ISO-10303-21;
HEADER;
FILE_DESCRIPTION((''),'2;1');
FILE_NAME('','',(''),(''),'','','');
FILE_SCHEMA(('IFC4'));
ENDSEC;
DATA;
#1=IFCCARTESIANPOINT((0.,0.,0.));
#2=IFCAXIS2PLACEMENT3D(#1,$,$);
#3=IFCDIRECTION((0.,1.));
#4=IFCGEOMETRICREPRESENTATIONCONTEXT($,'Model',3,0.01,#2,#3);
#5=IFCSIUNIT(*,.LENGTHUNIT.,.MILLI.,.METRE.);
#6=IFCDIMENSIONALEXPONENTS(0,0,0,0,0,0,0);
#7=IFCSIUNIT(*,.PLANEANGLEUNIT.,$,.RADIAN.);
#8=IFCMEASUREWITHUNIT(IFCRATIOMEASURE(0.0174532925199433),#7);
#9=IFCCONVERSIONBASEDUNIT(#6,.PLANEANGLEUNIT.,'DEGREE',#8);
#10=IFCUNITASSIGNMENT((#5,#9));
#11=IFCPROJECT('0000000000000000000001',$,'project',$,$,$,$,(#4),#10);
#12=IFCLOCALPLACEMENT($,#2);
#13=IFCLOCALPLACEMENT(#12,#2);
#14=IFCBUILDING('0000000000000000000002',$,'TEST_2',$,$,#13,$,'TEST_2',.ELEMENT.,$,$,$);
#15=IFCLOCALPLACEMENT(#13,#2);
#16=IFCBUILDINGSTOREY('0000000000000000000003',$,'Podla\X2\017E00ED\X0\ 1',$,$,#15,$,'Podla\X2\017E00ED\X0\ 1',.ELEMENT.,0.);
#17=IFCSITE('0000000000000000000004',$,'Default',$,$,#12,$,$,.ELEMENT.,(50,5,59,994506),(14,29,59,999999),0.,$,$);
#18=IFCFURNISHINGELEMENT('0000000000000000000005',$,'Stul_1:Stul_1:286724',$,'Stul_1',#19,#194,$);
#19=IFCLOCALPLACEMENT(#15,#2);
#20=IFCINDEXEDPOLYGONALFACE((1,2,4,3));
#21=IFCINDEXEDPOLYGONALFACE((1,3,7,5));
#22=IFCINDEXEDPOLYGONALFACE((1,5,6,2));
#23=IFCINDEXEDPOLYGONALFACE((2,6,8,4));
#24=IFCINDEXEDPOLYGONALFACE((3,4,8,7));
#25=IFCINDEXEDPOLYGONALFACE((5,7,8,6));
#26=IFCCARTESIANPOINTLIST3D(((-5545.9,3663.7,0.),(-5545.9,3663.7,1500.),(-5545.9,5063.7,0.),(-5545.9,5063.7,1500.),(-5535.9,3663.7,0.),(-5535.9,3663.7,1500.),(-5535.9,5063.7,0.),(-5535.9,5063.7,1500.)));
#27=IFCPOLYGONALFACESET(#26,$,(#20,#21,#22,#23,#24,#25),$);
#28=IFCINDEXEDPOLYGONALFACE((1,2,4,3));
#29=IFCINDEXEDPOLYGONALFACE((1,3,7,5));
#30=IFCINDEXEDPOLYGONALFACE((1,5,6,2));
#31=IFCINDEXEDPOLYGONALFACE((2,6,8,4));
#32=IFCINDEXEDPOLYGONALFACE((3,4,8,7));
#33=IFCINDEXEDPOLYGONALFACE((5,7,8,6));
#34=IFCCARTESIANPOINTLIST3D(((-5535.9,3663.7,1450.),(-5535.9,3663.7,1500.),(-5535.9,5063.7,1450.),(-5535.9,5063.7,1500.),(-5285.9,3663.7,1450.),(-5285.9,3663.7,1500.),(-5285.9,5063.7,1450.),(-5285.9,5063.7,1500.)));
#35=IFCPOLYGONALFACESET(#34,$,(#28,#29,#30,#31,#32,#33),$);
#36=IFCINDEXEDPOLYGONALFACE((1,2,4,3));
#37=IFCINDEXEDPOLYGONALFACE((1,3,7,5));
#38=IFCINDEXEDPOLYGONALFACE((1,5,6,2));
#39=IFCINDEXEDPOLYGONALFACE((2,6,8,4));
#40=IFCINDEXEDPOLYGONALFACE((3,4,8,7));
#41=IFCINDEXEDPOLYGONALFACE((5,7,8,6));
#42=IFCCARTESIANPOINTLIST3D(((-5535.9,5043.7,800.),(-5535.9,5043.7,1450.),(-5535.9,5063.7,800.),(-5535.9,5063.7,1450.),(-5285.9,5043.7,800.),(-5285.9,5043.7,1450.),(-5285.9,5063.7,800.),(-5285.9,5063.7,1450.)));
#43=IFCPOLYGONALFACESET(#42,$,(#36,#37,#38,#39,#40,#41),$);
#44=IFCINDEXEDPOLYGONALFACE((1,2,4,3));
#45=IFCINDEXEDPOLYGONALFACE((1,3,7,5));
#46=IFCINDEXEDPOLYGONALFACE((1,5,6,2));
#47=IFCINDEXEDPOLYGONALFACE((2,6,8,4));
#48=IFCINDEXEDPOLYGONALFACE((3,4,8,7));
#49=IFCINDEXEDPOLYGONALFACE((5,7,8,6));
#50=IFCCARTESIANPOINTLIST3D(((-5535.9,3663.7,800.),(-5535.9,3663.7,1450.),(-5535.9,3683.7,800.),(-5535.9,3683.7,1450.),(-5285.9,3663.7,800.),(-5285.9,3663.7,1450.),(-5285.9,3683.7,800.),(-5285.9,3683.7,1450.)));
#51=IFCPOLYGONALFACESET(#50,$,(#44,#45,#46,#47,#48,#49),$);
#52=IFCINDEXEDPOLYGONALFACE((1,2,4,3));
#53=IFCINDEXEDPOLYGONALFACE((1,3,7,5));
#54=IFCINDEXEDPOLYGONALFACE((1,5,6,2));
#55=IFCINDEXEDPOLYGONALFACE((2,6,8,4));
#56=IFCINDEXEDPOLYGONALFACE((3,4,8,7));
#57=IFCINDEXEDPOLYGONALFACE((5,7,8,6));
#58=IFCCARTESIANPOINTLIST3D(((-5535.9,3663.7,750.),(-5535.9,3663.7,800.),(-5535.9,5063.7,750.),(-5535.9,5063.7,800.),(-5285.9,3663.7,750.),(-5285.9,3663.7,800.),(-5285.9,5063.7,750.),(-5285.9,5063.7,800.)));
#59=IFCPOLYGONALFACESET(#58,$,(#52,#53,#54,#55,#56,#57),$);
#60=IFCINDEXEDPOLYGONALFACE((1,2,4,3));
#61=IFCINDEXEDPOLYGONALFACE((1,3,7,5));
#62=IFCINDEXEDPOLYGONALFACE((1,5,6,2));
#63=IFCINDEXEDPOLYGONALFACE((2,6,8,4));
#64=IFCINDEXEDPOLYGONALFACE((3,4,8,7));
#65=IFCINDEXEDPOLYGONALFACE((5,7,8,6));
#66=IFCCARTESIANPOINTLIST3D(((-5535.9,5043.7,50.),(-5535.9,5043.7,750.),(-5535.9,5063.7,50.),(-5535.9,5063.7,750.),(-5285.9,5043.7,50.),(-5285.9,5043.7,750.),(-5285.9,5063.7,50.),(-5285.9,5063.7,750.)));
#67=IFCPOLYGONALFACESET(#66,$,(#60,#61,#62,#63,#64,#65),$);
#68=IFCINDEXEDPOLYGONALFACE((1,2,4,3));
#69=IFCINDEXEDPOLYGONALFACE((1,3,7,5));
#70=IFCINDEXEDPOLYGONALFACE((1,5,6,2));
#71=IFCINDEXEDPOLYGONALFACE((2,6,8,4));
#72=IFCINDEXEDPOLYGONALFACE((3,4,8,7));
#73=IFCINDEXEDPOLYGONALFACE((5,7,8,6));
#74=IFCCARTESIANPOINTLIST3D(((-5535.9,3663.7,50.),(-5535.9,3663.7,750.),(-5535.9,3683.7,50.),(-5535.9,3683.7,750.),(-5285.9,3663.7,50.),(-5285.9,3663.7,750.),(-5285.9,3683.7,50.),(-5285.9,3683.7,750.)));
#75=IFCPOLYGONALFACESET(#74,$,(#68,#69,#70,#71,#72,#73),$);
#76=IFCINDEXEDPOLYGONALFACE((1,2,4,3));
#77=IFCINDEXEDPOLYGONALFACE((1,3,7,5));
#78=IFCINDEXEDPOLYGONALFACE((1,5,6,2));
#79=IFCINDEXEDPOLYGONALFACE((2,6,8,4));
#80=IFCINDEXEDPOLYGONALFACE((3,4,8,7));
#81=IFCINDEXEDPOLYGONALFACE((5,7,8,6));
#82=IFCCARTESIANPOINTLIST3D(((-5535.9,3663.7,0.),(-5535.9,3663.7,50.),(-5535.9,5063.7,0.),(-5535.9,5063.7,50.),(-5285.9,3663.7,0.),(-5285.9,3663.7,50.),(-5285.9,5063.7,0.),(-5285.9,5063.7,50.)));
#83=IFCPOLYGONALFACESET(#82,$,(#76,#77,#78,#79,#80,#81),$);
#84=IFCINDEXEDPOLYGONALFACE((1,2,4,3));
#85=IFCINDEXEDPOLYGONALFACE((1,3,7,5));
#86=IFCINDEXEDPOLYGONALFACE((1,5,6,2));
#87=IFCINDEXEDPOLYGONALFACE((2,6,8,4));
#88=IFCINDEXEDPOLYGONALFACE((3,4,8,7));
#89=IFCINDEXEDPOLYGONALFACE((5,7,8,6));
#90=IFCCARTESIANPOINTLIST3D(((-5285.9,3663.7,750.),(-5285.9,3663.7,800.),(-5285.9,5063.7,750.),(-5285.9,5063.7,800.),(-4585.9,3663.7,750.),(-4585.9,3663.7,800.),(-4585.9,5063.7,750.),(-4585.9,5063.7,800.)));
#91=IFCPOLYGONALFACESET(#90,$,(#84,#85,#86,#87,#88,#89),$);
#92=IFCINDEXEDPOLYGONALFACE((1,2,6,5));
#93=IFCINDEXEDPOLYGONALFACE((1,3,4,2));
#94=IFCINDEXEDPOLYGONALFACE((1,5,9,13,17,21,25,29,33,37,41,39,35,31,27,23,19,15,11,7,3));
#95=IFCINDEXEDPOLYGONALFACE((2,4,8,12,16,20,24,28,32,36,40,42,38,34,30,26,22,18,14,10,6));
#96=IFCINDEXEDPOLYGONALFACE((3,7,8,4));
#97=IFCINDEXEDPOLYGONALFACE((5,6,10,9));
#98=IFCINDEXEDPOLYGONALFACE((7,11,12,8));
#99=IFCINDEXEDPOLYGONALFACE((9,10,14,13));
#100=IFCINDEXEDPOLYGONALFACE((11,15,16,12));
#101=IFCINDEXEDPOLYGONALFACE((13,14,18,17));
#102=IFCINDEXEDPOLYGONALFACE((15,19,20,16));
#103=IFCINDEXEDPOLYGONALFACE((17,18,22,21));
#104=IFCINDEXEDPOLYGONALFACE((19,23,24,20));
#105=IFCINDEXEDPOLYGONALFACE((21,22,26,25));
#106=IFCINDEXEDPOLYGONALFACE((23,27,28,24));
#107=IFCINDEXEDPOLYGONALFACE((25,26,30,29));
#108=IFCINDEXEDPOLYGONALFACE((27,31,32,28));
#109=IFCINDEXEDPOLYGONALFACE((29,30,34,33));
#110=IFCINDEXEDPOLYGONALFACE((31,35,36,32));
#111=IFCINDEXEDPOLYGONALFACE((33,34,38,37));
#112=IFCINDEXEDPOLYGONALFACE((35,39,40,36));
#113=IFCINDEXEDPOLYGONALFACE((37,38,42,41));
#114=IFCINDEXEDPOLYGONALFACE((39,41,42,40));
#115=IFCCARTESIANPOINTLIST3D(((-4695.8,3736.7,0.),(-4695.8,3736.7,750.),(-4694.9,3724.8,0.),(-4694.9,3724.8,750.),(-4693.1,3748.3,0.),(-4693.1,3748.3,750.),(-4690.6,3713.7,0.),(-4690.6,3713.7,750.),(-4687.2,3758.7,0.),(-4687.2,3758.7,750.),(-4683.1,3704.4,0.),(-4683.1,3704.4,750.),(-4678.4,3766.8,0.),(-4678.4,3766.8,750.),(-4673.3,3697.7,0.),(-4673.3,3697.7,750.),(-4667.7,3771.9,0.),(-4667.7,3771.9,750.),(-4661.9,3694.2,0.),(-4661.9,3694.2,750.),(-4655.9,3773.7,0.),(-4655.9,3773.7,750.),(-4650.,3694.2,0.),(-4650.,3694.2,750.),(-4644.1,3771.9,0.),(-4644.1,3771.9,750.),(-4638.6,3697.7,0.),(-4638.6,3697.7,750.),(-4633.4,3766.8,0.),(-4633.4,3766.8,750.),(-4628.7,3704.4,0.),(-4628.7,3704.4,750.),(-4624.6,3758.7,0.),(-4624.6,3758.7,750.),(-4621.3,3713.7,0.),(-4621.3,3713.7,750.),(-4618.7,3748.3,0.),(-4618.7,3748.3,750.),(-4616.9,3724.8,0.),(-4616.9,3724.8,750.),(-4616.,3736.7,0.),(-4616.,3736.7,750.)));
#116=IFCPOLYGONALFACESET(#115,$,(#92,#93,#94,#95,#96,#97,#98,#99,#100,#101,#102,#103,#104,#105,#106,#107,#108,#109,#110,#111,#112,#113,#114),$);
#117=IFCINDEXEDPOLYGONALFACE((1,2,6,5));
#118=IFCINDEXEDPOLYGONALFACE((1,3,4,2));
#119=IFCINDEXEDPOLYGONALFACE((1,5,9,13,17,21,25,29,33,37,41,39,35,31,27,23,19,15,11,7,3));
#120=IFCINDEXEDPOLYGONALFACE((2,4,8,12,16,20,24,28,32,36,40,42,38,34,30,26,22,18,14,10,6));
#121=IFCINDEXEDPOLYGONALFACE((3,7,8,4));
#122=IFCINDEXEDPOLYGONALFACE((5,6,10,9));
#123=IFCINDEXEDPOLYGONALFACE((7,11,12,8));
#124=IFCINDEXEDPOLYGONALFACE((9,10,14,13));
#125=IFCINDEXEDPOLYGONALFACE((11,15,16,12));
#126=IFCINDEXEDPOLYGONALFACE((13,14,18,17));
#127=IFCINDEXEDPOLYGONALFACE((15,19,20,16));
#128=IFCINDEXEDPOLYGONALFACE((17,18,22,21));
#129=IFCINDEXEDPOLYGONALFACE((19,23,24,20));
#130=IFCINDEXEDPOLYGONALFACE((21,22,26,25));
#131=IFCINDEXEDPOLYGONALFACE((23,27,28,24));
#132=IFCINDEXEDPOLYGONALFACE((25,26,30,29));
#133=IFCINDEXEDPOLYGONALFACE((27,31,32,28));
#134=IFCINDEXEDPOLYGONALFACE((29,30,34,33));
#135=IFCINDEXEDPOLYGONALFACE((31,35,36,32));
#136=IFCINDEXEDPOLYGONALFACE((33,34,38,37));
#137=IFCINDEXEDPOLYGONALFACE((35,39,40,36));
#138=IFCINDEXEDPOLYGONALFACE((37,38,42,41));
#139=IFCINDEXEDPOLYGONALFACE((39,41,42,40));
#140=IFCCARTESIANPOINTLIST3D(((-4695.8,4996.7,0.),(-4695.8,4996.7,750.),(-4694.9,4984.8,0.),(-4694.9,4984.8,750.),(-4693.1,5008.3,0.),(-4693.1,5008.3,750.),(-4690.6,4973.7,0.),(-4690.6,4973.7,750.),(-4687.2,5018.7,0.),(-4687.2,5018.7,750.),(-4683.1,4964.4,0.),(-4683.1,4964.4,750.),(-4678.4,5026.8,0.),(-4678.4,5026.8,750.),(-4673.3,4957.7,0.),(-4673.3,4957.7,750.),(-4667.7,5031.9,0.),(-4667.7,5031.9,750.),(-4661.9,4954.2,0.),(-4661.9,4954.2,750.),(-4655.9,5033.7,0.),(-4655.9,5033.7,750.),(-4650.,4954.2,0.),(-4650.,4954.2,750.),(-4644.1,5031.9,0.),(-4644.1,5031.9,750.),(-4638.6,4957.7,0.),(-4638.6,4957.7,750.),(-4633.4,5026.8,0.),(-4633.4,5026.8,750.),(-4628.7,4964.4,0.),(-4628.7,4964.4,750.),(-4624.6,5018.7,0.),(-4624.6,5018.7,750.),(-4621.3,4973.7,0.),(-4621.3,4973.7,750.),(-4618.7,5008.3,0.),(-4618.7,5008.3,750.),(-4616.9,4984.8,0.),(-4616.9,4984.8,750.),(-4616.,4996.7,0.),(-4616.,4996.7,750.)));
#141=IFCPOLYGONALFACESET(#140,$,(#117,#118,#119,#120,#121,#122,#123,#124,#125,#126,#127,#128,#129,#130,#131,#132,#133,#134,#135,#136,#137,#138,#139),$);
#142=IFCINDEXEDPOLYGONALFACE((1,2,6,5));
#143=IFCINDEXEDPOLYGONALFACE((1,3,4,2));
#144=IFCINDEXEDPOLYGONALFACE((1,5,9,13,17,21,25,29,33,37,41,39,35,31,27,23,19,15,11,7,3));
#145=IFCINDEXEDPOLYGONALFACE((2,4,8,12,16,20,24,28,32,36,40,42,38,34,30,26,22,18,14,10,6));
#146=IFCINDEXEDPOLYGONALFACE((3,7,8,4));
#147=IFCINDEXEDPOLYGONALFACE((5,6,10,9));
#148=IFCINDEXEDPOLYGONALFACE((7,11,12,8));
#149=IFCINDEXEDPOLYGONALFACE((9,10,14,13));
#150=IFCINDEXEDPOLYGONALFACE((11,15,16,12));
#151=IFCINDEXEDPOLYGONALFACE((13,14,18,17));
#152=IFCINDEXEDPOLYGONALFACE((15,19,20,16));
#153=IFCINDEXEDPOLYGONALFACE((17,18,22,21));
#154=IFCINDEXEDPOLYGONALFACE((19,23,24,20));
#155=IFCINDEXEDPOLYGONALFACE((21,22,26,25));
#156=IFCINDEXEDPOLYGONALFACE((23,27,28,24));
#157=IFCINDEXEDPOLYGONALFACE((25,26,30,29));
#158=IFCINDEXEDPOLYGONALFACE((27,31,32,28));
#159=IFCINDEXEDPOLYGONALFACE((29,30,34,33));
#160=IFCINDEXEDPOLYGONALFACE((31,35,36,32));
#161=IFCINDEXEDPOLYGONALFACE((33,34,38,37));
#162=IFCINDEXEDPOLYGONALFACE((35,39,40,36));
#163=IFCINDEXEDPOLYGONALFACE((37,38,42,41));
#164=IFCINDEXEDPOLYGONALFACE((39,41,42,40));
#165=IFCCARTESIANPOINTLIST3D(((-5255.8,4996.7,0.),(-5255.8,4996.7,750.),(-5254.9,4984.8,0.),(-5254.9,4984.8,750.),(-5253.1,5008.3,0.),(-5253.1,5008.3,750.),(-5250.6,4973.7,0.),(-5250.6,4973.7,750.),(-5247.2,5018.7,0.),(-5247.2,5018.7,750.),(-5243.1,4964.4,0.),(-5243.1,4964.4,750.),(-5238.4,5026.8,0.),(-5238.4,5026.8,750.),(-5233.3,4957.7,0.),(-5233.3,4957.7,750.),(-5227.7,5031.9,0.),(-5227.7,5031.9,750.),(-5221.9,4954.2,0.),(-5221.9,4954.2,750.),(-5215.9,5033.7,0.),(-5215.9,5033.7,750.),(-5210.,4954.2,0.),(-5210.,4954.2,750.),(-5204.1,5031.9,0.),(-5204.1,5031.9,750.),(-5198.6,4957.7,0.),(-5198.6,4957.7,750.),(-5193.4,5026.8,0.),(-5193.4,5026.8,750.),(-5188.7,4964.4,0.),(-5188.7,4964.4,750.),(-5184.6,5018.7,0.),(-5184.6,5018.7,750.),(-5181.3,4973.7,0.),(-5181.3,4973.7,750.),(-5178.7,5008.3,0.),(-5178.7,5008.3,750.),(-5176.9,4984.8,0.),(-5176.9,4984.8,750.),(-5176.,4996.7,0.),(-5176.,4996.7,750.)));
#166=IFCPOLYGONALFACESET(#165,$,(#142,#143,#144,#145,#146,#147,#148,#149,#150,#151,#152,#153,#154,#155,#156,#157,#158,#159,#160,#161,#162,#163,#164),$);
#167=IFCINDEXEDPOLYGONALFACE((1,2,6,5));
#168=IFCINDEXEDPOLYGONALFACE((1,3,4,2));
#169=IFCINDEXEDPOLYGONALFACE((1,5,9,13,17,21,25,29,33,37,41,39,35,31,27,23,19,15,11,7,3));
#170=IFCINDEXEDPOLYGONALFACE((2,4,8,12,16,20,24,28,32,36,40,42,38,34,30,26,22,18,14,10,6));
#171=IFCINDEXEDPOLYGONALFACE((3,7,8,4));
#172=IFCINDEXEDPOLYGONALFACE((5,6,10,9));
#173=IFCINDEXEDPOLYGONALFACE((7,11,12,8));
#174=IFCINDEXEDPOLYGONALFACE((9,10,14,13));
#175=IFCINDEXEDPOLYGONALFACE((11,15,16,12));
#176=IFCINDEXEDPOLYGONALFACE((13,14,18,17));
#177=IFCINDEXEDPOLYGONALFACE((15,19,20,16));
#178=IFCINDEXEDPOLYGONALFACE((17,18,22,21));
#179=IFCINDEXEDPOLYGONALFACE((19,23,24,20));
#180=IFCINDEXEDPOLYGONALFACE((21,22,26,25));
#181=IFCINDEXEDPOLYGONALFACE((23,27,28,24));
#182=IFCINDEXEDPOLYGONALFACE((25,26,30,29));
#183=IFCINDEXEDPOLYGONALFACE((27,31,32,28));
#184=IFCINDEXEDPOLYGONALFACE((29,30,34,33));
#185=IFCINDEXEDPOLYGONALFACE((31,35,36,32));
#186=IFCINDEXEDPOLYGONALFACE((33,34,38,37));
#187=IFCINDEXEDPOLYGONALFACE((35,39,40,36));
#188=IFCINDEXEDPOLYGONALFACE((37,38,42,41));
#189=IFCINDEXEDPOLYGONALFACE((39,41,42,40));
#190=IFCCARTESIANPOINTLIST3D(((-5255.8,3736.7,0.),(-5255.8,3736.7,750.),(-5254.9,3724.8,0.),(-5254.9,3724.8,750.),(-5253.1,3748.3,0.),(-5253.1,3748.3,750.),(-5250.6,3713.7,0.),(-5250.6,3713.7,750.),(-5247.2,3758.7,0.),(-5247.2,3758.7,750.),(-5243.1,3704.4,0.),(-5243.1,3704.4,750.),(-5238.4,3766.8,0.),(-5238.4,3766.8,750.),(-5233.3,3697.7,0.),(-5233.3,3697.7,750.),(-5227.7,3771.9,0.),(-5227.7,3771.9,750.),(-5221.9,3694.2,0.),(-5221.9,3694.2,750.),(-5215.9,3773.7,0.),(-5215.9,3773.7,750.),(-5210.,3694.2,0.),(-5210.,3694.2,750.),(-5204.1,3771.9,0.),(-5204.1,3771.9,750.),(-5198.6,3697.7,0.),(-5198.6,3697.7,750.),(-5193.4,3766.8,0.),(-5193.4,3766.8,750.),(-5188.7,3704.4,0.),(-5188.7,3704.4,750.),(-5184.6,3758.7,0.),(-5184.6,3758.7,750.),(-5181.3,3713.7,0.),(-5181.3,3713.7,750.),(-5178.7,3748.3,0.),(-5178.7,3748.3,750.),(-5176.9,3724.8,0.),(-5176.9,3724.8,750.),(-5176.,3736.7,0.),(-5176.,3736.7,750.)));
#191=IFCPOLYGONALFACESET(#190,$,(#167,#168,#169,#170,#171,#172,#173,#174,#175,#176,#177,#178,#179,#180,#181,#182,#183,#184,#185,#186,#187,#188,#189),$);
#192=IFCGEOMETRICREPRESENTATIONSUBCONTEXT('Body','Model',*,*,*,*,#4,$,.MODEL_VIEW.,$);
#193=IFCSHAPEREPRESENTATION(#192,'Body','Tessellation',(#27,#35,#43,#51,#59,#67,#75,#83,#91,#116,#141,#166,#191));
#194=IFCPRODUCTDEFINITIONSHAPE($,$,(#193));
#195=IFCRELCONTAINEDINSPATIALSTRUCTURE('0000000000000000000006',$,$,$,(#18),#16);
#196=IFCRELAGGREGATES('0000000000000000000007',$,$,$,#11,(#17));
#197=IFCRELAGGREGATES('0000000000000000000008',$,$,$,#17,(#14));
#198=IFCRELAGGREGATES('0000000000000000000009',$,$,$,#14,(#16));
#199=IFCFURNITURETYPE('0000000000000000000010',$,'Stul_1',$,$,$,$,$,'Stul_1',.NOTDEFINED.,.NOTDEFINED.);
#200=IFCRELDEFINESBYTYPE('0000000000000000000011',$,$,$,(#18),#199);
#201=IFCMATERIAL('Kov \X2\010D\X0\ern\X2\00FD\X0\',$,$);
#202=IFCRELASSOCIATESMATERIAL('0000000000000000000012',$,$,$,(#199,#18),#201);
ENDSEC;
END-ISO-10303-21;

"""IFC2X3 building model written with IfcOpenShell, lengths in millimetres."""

from ifc_helpers import new_model, entity, si_unit, converted_unit, direction, frame, frame_2d, origin, origin_2d_with_axis, place, context, subcontext, project, spatial, rectangle, circle, extrude, source, transform, mapped, material, type_object, type_shapes, element, save


model = new_model("IFC2X3")

# Units and contexts
model_context = context("Model", 3, precision=0.01, world=origin(), true_north=direction((0.0, 1.0)))
body_context = subcontext(model_context, "Body", "Model", "MODEL_VIEW")
ifc_project = project(units=[si_unit("LENGTHUNIT", "METRE", prefix="MILLI"), converted_unit("PLANEANGLEUNIT", "DEGREE", entity("IfcRatioMeasure", 0.0174532925199433), si_unit("PLANEANGLEUNIT", "RADIAN"), dimensions=[0, 0, 0, 0, 0, 0, 0])], contexts=[model_context])

# Site, building, storey
site_placement = place(None, origin())
site = spatial("IfcSite", under=ifc_project, at=site_placement, Name="Default", CompositionType="ELEMENT", RefLatitude=(50, 5, 59, 994506), RefLongitude=(14, 29, 59, 999999), RefElevation=0.0)
building_placement = place(site_placement, origin())
building = spatial("IfcBuilding", under=site, at=building_placement, Name="TEST_2", LongName="TEST_2", CompositionType="ELEMENT")
storey_placement = place(building_placement, origin())
storey = spatial("IfcBuildingStorey", under=building, at=storey_placement, Name="Podlaží 1", LongName="Podlaží 1", CompositionType="ELEMENT", Elevation=0.0)

# Furnishing element
ifc_material_1 = material(Name="Kov černý")
furniture_type = type_object("IfcFurnitureType", Name="Stul_1", ElementType="Stul_1", material=ifc_material_1)
shared_shape_1 = source(origin(), body_context, "Body", "SweptSolid", [
    extrude(rectangle(XDim=1400.0, YDim=10.0, at=origin_2d_with_axis()), frame((0.0, 605.0, 0.0), z_axis=(0.0, 0.0, 1.0), x_axis=(-1.0, 0.0, 0.0)), (0.0, 0.0, 1.0), 1500.0),
    extrude(rectangle(XDim=1400.0, YDim=250.0, at=frame_2d((0.0, 0.0), x_axis=(1.0, 0.0))), frame((0.0, 475.0, 1450.0), z_axis=(0.0, 0.0, 1.0), x_axis=(-1.0, 0.0, 0.0)), (0.0, 0.0, 1.0), 50.0),
    extrude(rectangle(XDim=20.0, YDim=250.0, at=origin_2d_with_axis()), frame((690.0, 475.0, 800.0), z_axis=(0.0, 0.0, 1.0), x_axis=(-1.0, 0.0, 0.0)), (0.0, 0.0, 1.0), 650.0),
    extrude(rectangle(XDim=20.0, YDim=250.0, at=frame_2d((0.0, 0.0), x_axis=(1.0, 0.0))), frame((-690.0, 475.0, 800.0), z_axis=(0.0, 0.0, 1.0), x_axis=(-1.0, 0.0, 0.0)), (0.0, 0.0, 1.0), 650.0),
    extrude(rectangle(XDim=1400.0, YDim=250.0, at=origin_2d_with_axis()), frame((0.0, 475.0, 750.0), z_axis=(0.0, 0.0, 1.0), x_axis=(-1.0, 0.0, 0.0)), (0.0, 0.0, 1.0), 50.0),
    extrude(rectangle(XDim=20.0, YDim=250.0, at=origin_2d_with_axis()), frame((690.0, 475.0, 50.0), z_axis=(0.0, 0.0, 1.0), x_axis=(-1.0, 0.0, 0.0)), (0.0, 0.0, 1.0), 700.0),
    extrude(rectangle(XDim=20.0, YDim=250.0, at=frame_2d((0.0, 0.0), x_axis=(1.0, 0.0))), frame((-690.0, 475.0, 50.0), z_axis=(0.0, 0.0, 1.0), x_axis=(-1.0, 0.0, 0.0)), (0.0, 0.0, 1.0), 700.0),
    extrude(rectangle(XDim=1400.0, YDim=250.0, at=origin_2d_with_axis()), frame((0.0, 475.0, 0.0), z_axis=(0.0, 0.0, 1.0), x_axis=(-1.0, 0.0, 0.0)), (0.0, 0.0, 1.0), 50.0),
    extrude(rectangle(XDim=1400.0, YDim=700.0, at=origin_2d_with_axis()), frame((0.0, 0.0, 750.0), z_axis=(0.0, 0.0, 1.0), x_axis=(-1.0, 0.0, 0.0)), (0.0, 0.0, 1.0), 50.0),
    extrude(circle(Radius=40.0, at=frame_2d((0.0, 0.0), x_axis=(1.0, 0.0))), frame((-630.0, -280.0, 0.0)), (0.0, 0.0, 1.0), 750.0),
    extrude(circle(Radius=40.0, at=frame_2d((0.0, 0.0), x_axis=(1.0, 0.0))), frame((630.0, -280.0, 0.0)), (0.0, 0.0, 1.0), 750.0),
    extrude(circle(Radius=40.0, at=frame_2d((0.0, 0.0), x_axis=(1.0, 0.0))), frame((630.0, 280.0, 0.0)), (0.0, 0.0, 1.0), 750.0),
    extrude(circle(Radius=40.0, at=frame_2d((0.0, 0.0), x_axis=(1.0, 0.0))), frame((-630.0, 280.0, 0.0)), (0.0, 0.0, 1.0), 750.0),
])
type_shapes(furniture_type, [shared_shape_1])
for number, where, z_axis, x_axis, name in (
    (1, (-4935.9, 4363.7, 0.0), (0.0, 0.0, 1.0), (0.0, 1.0, 0.0), "Stul_1:Stul_1:286724"),
):
    element("IfcFurnishingElement", number, at=place(storey_placement, frame(where, z_axis=z_axis, x_axis=x_axis)), inside=storey, type_object=furniture_type, material=ifc_material_1, Name=name, ObjectType="Stul_1", context=body_context, shape_type="MappedRepresentation", body=[
        mapped(shared_shape_1, transform((0.0, 0.0, 0.0), scale=1.0)),
    ])

save(model, "model.ifc")
